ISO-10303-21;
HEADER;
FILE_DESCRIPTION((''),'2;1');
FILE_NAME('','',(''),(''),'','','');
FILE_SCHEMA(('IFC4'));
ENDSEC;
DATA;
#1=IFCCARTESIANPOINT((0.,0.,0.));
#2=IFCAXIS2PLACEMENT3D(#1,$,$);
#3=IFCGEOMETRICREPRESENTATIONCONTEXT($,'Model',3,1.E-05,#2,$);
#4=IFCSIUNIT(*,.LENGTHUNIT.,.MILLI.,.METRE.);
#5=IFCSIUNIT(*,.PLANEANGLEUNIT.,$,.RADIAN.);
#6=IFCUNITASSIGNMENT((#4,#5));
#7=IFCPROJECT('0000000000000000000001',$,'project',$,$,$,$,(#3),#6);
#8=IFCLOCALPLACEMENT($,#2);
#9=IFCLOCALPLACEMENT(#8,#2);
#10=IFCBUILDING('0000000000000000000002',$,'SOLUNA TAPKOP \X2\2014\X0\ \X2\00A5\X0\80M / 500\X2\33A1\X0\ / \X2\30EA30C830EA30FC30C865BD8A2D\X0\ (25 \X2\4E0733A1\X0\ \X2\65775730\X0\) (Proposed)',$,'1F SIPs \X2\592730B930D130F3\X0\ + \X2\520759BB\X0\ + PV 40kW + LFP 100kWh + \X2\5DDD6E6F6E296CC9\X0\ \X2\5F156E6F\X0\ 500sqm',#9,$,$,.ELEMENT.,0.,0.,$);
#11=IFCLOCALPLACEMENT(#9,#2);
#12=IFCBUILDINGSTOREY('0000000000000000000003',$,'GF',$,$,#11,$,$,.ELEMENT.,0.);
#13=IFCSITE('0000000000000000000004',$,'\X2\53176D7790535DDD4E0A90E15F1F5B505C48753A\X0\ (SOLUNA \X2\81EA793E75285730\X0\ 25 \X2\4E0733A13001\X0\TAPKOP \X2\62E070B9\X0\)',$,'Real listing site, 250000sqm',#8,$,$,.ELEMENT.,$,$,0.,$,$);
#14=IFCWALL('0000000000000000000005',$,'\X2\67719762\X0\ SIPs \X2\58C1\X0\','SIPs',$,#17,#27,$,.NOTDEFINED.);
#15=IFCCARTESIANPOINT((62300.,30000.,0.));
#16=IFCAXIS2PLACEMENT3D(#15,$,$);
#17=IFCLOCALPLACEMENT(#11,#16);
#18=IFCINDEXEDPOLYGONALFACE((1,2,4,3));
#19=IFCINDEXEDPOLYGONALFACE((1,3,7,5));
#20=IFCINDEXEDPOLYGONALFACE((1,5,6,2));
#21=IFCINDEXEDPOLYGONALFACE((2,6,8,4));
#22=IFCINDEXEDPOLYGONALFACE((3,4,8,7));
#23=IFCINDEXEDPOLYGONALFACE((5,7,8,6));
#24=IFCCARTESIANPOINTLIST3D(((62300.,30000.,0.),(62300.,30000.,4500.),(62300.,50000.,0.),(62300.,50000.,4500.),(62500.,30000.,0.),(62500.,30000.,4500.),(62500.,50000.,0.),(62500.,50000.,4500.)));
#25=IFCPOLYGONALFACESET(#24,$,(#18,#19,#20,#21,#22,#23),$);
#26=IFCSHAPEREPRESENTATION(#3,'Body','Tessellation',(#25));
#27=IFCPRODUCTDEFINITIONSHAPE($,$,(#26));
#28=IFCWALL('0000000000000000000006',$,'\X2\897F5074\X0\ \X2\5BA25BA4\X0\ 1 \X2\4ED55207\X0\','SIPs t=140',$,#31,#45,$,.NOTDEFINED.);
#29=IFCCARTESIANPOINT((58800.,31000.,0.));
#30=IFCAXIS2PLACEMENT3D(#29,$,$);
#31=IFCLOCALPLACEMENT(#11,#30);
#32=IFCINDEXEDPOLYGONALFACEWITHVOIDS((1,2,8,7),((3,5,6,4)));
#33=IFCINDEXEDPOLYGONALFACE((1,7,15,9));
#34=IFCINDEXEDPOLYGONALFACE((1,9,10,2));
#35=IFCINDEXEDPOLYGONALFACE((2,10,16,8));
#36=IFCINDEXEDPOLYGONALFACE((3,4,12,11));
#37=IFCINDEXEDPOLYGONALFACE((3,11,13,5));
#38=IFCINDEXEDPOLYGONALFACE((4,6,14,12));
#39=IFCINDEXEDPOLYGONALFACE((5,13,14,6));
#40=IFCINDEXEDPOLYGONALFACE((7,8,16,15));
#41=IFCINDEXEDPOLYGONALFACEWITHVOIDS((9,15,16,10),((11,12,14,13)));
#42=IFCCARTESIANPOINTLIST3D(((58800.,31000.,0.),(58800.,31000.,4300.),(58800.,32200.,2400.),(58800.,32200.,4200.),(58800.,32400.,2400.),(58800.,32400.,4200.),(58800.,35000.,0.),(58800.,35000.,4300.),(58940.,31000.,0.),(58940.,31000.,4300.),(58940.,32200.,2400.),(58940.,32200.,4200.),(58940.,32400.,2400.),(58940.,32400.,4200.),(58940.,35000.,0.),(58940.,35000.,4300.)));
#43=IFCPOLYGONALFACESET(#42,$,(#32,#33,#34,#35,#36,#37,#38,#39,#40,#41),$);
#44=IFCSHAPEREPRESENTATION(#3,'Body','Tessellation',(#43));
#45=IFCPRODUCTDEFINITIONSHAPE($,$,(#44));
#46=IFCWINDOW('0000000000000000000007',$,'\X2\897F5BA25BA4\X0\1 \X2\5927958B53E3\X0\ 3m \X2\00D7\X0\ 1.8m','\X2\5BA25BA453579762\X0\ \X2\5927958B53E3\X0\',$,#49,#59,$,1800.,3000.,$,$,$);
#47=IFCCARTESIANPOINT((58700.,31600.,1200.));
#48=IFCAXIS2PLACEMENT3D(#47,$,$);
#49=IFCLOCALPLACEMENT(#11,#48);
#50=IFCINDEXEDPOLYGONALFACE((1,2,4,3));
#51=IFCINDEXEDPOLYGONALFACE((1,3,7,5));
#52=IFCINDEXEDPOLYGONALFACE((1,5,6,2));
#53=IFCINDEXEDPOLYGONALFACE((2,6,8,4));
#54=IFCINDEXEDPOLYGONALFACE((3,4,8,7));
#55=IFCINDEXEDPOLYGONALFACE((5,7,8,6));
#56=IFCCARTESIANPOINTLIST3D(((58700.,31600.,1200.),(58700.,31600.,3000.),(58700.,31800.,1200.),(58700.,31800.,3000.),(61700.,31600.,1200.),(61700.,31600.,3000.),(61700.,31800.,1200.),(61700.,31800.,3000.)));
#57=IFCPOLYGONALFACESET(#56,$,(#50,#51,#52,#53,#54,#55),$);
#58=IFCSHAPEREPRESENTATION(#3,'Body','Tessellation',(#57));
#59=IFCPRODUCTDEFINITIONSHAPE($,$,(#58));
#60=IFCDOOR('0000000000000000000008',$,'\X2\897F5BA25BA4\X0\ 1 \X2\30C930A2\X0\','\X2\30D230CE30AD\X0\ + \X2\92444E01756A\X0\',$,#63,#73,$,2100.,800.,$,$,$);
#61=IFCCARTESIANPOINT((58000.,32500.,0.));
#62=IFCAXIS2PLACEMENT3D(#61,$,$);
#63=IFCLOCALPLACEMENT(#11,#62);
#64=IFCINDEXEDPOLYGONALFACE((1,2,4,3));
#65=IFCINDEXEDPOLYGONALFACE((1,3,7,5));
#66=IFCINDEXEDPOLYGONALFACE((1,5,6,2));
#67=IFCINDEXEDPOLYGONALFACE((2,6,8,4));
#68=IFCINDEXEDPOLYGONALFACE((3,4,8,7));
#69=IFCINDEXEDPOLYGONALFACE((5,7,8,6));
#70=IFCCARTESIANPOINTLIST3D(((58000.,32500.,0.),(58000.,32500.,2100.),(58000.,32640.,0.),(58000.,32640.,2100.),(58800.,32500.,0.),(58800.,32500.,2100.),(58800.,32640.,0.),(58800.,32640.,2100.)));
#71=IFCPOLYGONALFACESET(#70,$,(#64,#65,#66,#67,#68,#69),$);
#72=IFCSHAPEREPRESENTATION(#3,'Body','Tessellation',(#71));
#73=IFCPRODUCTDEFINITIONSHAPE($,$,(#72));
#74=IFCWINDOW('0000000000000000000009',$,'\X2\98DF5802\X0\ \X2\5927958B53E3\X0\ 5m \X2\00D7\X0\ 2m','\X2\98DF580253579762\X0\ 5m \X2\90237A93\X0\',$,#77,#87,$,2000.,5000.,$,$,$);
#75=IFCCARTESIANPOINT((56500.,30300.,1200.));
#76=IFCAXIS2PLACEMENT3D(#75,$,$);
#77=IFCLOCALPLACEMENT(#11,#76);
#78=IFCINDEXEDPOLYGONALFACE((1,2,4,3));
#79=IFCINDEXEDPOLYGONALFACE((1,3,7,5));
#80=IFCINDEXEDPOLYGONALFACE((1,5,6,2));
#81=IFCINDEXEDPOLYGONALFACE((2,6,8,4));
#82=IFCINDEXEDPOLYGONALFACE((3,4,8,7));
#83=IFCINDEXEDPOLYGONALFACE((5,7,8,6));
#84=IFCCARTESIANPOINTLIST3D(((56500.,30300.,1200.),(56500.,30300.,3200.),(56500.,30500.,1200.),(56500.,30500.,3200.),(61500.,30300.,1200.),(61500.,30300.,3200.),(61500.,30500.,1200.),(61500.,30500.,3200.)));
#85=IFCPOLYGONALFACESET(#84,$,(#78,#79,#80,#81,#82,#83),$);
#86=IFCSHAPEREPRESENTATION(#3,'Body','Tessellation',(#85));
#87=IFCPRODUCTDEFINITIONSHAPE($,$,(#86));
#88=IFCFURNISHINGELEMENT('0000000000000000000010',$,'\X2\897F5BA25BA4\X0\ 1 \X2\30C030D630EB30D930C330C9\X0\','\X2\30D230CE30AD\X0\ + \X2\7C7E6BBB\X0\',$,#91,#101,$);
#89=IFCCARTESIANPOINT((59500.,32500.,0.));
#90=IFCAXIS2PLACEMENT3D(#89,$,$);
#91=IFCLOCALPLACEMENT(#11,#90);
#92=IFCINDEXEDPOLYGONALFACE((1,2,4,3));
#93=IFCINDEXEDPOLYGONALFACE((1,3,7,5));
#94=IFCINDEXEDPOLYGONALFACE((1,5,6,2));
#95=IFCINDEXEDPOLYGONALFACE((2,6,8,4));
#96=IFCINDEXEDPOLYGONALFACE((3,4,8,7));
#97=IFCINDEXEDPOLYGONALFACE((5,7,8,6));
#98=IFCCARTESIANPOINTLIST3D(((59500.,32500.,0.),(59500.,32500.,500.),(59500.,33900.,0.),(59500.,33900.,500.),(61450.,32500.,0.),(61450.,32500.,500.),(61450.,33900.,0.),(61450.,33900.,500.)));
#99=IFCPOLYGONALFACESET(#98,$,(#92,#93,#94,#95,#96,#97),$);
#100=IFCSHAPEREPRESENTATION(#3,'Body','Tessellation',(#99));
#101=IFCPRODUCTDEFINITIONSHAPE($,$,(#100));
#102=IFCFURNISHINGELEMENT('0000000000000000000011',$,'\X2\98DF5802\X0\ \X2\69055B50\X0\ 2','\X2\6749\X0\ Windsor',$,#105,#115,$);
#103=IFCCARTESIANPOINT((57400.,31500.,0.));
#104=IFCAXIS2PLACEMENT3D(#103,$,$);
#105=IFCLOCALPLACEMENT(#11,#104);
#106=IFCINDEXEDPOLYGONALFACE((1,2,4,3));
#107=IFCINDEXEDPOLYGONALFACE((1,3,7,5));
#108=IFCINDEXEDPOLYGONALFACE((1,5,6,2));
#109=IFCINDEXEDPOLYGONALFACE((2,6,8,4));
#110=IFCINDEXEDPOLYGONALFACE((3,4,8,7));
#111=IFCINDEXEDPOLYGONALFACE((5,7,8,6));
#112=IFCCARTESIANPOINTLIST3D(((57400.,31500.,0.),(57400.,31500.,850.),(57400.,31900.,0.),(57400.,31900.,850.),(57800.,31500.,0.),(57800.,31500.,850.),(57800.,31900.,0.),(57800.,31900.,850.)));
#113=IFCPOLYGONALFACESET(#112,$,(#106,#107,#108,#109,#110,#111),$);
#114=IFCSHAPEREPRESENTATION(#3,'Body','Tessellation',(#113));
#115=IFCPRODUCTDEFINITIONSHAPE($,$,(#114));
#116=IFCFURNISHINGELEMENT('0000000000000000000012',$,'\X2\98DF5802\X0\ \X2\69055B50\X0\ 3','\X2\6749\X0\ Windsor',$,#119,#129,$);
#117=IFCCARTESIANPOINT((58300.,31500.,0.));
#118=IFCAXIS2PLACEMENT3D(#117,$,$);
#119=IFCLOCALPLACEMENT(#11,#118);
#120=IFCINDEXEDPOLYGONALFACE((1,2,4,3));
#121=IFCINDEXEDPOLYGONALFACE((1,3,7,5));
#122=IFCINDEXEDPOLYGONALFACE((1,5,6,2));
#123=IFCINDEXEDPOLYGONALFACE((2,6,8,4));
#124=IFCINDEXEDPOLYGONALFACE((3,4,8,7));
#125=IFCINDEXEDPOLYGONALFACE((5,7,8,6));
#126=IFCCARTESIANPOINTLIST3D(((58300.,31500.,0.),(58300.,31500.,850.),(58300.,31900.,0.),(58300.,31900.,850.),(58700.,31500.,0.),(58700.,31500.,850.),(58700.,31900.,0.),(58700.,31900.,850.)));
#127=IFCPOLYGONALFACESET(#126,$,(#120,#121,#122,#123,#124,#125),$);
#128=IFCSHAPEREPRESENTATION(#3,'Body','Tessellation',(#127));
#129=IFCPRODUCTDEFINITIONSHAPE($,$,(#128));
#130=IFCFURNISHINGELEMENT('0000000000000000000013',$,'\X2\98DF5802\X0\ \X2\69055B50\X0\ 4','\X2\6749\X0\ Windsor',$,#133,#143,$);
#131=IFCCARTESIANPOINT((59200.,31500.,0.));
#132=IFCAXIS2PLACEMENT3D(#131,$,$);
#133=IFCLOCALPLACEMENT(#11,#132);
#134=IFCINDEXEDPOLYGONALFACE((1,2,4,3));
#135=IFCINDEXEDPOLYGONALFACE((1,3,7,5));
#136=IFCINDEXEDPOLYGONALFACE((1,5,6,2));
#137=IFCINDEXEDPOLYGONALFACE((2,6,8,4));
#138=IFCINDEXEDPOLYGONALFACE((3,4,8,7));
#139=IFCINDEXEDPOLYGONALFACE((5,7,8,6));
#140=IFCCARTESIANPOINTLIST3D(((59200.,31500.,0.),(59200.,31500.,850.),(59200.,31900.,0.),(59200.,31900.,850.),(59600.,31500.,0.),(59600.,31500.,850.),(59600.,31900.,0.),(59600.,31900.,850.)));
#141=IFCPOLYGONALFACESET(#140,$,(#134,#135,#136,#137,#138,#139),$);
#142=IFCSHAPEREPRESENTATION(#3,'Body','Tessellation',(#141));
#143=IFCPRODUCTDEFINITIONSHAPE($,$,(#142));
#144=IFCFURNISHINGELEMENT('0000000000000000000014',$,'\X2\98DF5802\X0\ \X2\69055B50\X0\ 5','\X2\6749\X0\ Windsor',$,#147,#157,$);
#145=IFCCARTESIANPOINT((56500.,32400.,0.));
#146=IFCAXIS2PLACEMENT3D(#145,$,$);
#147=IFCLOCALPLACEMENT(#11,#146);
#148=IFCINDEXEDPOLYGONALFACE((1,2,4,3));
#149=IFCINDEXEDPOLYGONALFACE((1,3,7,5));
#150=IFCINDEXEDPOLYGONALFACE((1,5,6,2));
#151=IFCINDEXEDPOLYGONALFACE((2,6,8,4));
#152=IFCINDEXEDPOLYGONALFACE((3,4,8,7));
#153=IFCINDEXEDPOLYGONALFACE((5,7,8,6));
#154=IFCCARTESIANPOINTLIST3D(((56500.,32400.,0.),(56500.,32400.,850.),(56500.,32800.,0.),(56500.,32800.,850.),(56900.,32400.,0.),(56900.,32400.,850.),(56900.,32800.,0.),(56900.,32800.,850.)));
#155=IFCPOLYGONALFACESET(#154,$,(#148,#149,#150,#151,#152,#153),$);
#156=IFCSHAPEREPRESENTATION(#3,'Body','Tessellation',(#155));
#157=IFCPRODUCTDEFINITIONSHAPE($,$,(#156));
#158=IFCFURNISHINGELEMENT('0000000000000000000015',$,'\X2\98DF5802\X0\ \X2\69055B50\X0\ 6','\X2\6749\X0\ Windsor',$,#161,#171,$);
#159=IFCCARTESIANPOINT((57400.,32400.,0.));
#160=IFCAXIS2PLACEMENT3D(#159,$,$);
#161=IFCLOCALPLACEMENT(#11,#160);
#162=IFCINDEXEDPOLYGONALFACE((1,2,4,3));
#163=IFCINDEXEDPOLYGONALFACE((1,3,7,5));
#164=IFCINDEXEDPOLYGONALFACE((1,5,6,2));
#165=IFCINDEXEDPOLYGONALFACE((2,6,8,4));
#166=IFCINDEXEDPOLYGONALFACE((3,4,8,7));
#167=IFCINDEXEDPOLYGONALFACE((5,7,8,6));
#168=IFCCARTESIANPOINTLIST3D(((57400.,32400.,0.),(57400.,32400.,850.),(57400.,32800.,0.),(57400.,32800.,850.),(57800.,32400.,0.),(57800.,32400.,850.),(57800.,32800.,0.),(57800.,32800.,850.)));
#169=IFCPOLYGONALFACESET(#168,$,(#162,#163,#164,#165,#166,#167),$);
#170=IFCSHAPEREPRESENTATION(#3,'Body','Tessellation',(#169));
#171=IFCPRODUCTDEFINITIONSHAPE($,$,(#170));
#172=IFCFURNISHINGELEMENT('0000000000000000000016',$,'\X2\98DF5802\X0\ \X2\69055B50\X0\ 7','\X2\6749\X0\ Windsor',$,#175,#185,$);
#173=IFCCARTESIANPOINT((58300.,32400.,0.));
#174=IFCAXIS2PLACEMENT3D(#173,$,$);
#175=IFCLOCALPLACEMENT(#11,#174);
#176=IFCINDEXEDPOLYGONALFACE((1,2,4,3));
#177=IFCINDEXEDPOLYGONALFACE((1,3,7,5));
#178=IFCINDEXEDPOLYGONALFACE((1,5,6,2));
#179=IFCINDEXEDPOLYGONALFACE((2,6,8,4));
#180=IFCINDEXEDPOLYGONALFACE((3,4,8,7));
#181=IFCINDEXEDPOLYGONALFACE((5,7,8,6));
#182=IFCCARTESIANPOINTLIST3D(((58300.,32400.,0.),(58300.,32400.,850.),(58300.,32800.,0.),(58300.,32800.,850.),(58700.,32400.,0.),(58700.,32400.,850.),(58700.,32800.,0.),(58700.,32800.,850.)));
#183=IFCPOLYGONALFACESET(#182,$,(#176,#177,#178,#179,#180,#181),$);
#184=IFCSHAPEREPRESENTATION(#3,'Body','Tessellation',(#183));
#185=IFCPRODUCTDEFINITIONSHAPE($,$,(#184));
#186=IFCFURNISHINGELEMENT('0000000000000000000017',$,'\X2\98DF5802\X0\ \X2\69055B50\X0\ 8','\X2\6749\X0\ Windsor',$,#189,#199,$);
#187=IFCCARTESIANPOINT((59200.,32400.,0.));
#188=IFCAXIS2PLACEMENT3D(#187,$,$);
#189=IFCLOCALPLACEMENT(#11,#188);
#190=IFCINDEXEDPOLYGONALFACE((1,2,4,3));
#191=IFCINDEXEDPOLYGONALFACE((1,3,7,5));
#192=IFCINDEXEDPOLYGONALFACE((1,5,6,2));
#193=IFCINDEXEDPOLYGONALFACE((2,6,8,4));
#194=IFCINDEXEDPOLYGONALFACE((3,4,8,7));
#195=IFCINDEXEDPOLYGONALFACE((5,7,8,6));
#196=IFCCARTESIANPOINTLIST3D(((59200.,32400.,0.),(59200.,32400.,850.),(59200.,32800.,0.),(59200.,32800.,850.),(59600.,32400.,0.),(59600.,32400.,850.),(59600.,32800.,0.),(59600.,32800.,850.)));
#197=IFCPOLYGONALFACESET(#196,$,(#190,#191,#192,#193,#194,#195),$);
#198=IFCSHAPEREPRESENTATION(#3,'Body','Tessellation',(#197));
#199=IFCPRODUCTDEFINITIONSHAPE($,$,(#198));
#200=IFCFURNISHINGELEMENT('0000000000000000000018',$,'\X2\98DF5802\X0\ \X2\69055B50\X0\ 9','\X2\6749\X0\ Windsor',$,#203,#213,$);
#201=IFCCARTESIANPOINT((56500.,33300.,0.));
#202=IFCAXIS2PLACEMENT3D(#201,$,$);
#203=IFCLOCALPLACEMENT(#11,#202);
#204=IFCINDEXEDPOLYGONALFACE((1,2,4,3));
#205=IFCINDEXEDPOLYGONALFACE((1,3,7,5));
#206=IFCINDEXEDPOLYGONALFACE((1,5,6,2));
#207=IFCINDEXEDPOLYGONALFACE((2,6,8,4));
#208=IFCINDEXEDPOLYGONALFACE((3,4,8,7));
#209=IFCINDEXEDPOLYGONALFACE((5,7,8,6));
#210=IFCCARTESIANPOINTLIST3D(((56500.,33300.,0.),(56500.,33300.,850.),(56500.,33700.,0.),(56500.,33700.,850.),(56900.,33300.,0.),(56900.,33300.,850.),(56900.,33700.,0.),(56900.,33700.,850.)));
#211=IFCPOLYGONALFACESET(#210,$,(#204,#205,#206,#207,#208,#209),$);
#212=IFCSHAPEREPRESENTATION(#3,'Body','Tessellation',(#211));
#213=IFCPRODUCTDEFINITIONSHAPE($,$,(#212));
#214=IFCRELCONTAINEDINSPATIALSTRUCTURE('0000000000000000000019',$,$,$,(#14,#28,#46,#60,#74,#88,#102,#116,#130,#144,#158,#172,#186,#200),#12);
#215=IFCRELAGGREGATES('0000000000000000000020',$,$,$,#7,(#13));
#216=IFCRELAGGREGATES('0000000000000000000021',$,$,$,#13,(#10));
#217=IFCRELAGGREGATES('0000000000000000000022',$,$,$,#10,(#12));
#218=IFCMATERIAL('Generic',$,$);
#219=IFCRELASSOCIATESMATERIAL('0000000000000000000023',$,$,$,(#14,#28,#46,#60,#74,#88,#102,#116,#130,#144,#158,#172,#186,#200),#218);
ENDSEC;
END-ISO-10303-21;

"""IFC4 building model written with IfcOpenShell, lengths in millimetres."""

from ifc_helpers import new_model, si_unit, frame, frame_2d, origin, place, context, project, spatial, rectangle, extrude, material, element, fill, save


model = new_model("IFC4")

# Units and contexts
model_context = context("Model", 3, precision=1e-05, world=origin())
ifc_project = project(units=[si_unit("LENGTHUNIT", "METRE", prefix="MILLI"), si_unit("PLANEANGLEUNIT", "RADIAN")], contexts=[model_context])

# Site, building, storey
site_placement = place(None, origin())
site = spatial("IfcSite", under=ifc_project, at=site_placement, Name="北海道川上郡弟子屈町 (SOLUNA 自社用地 25 万㎡、TAPKOP 拠点)", ObjectType="Real listing site, 250000sqm", CompositionType="ELEMENT", RefElevation=0.0)
building_placement = place(site_placement, origin())
building = spatial("IfcBuilding", under=site, at=building_placement, Name="SOLUNA TAPKOP — ¥80M / 500㎡ / リトリート施設 (25 万㎡ 敷地) (Proposed)", ObjectType="1F SIPs 大スパン + 切妻 + PV 40kW + LFP 100kWh + 川湯温泉 引湯 500sqm", CompositionType="ELEMENT", ElevationOfRefHeight=0.0, ElevationOfTerrain=0.0)
storey_placement = place(building_placement, origin())
storey = spatial("IfcBuildingStorey", under=building, at=storey_placement, Name="GF", CompositionType="ELEMENT", Elevation=0.0)

# Wall
ifc_material = material(Name="Generic")
wall_1_placement = place(storey_placement, frame((62300.0, 30000.0, 0.0)))
element("IfcWall", 1, at=wall_1_placement, inside=storey, material=ifc_material, Name="東面 SIPs 壁", Description="SIPs", PredefinedType="NOTDEFINED", context=model_context, shape_type="SweptSolid", body=[
    extrude(rectangle(XDim=200.0, YDim=20000.0, at=frame_2d((100.0, 10000.0))), frame((62300.0, 30000.0, 0.0)), (0.0, 0.0, 1.0), 4500.0),
])

# Wall, opening, window
wall_2_placement = place(storey_placement, frame((58800.0, 31000.0, 0.0)))
wall_2 = element("IfcWall", 2, at=wall_2_placement, inside=storey, material=ifc_material, Name="西側 客室 1 仕切", Description="SIPs t=140", PredefinedType="NOTDEFINED", context=model_context, shape_type="SweptSolid", body=[
    extrude(rectangle(XDim=140.0, YDim=4000.0, at=frame_2d((70.0, 2000.0))), frame((58800.0, 31000.0, 0.0)), (0.0, 0.0, 1.0), 4300.0),
])
opening_placement = place(storey_placement, frame((58700.0, 31600.0, 1200.0)))
opening = element("IfcOpeningElement", 3, at=opening_placement, cuts=wall_2, PredefinedType="NOTDEFINED", context=model_context, shape_type="SweptSolid", body=[
    extrude(rectangle(XDim=3000.0, YDim=200.0, at=frame_2d((1500.0, 100.0))), frame((58700.0, 31600.0, 1200.0)), (0.0, 0.0, 1.0), 1800.0),
])
window_1_placement = place(storey_placement, frame((58700.0, 31600.0, 1200.0)))
window_1 = element("IfcWindow", 4, at=window_1_placement, inside=storey, material=ifc_material, Name="西客室1 大開口 3m × 1.8m", Description="客室南面 大開口", OverallHeight=1800.0, OverallWidth=3000.0, context=model_context, shape_type="SweptSolid", body=[
    extrude(rectangle(XDim=3000.0, YDim=200.0, at=frame_2d((1500.0, 100.0))), frame((58700.0, 31600.0, 1200.0)), (0.0, 0.0, 1.0), 1800.0),
])
fill(opening, window_1)

# Door
door_placement = place(storey_placement, frame((58000.0, 32500.0, 0.0)))
element("IfcDoor", 5, at=door_placement, inside=storey, material=ifc_material, Name="西客室 1 ドア", Description="ヒノキ + 鉄丁番", OverallHeight=2100.0, OverallWidth=800.0, context=model_context, shape_type="SweptSolid", body=[
    extrude(rectangle(XDim=800.0, YDim=140.0, at=frame_2d((400.0, 70.0))), frame((58000.0, 32500.0, 0.0)), (0.0, 0.0, 1.0), 2100.0),
])

# Window
window_2_placement = place(storey_placement, frame((56500.0, 30300.0, 1200.0)))
element("IfcWindow", 6, at=window_2_placement, inside=storey, material=ifc_material, Name="食堂 大開口 5m × 2m", Description="食堂南面 5m 連窓", OverallHeight=2000.0, OverallWidth=5000.0, context=model_context, shape_type="SweptSolid", body=[
    extrude(rectangle(XDim=5000.0, YDim=200.0, at=frame_2d((2500.0, 100.0))), frame((56500.0, 30300.0, 1200.0)), (0.0, 0.0, 1.0), 2000.0),
])

# Furnishing elements
furnishing_1_placement = place(storey_placement, frame((59500.0, 32500.0, 0.0)))
element("IfcFurnishingElement", 7, at=furnishing_1_placement, inside=storey, material=ifc_material, Name="西客室 1 ダブルベッド", Description="ヒノキ + 籾殻", context=model_context, shape_type="SweptSolid", body=[
    extrude(rectangle(XDim=1950.0, YDim=1400.0, at=frame_2d((975.0, 700.0))), frame((59500.0, 32500.0, 0.0)), (0.0, 0.0, 1.0), 500.0),
])
furnishing_2_placement = place(storey_placement, frame((57400.0, 31500.0, 0.0)))
element("IfcFurnishingElement", 8, at=furnishing_2_placement, inside=storey, material=ifc_material, Name="食堂 椅子 2", Description="杉 Windsor", context=model_context, shape_type="SweptSolid", body=[
    extrude(rectangle(XDim=400.0, YDim=400.0, at=frame_2d((200.0, 200.0))), frame((57400.0, 31500.0, 0.0)), (0.0, 0.0, 1.0), 850.0),
])
furnishing_3_placement = place(storey_placement, frame((58300.0, 31500.0, 0.0)))
element("IfcFurnishingElement", 9, at=furnishing_3_placement, inside=storey, material=ifc_material, Name="食堂 椅子 3", Description="杉 Windsor", context=model_context, shape_type="SweptSolid", body=[
    extrude(rectangle(XDim=400.0, YDim=400.0, at=frame_2d((200.0, 200.0))), frame((58300.0, 31500.0, 0.0)), (0.0, 0.0, 1.0), 850.0),
])
furnishing_4_placement = place(storey_placement, frame((59200.0, 31500.0, 0.0)))
element("IfcFurnishingElement", 10, at=furnishing_4_placement, inside=storey, material=ifc_material, Name="食堂 椅子 4", Description="杉 Windsor", context=model_context, shape_type="SweptSolid", body=[
    extrude(rectangle(XDim=400.0, YDim=400.0, at=frame_2d((200.0, 200.0))), frame((59200.0, 31500.0, 0.0)), (0.0, 0.0, 1.0), 850.0),
])
furnishing_5_placement = place(storey_placement, frame((56500.0, 32400.0, 0.0)))
element("IfcFurnishingElement", 11, at=furnishing_5_placement, inside=storey, material=ifc_material, Name="食堂 椅子 5", Description="杉 Windsor", context=model_context, shape_type="SweptSolid", body=[
    extrude(rectangle(XDim=400.0, YDim=400.0, at=frame_2d((200.0, 200.0))), frame((56500.0, 32400.0, 0.0)), (0.0, 0.0, 1.0), 850.0),
])
furnishing_6_placement = place(storey_placement, frame((57400.0, 32400.0, 0.0)))
element("IfcFurnishingElement", 12, at=furnishing_6_placement, inside=storey, material=ifc_material, Name="食堂 椅子 6", Description="杉 Windsor", context=model_context, shape_type="SweptSolid", body=[
    extrude(rectangle(XDim=400.0, YDim=400.0, at=frame_2d((200.0, 200.0))), frame((57400.0, 32400.0, 0.0)), (0.0, 0.0, 1.0), 850.0),
])
furnishing_7_placement = place(storey_placement, frame((58300.0, 32400.0, 0.0)))
element("IfcFurnishingElement", 13, at=furnishing_7_placement, inside=storey, material=ifc_material, Name="食堂 椅子 7", Description="杉 Windsor", context=model_context, shape_type="SweptSolid", body=[
    extrude(rectangle(XDim=400.0, YDim=400.0, at=frame_2d((200.0, 200.0))), frame((58300.0, 32400.0, 0.0)), (0.0, 0.0, 1.0), 850.0),
])
furnishing_8_placement = place(storey_placement, frame((59200.0, 32400.0, 0.0)))
element("IfcFurnishingElement", 14, at=furnishing_8_placement, inside=storey, material=ifc_material, Name="食堂 椅子 8", Description="杉 Windsor", context=model_context, shape_type="SweptSolid", body=[
    extrude(rectangle(XDim=400.0, YDim=400.0, at=frame_2d((200.0, 200.0))), frame((59200.0, 32400.0, 0.0)), (0.0, 0.0, 1.0), 850.0),
])
furnishing_9_placement = place(storey_placement, frame((56500.0, 33300.0, 0.0)))
element("IfcFurnishingElement", 15, at=furnishing_9_placement, inside=storey, material=ifc_material, Name="食堂 椅子 9", Description="杉 Windsor", context=model_context, shape_type="SweptSolid", body=[
    extrude(rectangle(XDim=400.0, YDim=400.0, at=frame_2d((200.0, 200.0))), frame((56500.0, 33300.0, 0.0)), (0.0, 0.0, 1.0), 850.0),
])

save(model, "model.ifc")
